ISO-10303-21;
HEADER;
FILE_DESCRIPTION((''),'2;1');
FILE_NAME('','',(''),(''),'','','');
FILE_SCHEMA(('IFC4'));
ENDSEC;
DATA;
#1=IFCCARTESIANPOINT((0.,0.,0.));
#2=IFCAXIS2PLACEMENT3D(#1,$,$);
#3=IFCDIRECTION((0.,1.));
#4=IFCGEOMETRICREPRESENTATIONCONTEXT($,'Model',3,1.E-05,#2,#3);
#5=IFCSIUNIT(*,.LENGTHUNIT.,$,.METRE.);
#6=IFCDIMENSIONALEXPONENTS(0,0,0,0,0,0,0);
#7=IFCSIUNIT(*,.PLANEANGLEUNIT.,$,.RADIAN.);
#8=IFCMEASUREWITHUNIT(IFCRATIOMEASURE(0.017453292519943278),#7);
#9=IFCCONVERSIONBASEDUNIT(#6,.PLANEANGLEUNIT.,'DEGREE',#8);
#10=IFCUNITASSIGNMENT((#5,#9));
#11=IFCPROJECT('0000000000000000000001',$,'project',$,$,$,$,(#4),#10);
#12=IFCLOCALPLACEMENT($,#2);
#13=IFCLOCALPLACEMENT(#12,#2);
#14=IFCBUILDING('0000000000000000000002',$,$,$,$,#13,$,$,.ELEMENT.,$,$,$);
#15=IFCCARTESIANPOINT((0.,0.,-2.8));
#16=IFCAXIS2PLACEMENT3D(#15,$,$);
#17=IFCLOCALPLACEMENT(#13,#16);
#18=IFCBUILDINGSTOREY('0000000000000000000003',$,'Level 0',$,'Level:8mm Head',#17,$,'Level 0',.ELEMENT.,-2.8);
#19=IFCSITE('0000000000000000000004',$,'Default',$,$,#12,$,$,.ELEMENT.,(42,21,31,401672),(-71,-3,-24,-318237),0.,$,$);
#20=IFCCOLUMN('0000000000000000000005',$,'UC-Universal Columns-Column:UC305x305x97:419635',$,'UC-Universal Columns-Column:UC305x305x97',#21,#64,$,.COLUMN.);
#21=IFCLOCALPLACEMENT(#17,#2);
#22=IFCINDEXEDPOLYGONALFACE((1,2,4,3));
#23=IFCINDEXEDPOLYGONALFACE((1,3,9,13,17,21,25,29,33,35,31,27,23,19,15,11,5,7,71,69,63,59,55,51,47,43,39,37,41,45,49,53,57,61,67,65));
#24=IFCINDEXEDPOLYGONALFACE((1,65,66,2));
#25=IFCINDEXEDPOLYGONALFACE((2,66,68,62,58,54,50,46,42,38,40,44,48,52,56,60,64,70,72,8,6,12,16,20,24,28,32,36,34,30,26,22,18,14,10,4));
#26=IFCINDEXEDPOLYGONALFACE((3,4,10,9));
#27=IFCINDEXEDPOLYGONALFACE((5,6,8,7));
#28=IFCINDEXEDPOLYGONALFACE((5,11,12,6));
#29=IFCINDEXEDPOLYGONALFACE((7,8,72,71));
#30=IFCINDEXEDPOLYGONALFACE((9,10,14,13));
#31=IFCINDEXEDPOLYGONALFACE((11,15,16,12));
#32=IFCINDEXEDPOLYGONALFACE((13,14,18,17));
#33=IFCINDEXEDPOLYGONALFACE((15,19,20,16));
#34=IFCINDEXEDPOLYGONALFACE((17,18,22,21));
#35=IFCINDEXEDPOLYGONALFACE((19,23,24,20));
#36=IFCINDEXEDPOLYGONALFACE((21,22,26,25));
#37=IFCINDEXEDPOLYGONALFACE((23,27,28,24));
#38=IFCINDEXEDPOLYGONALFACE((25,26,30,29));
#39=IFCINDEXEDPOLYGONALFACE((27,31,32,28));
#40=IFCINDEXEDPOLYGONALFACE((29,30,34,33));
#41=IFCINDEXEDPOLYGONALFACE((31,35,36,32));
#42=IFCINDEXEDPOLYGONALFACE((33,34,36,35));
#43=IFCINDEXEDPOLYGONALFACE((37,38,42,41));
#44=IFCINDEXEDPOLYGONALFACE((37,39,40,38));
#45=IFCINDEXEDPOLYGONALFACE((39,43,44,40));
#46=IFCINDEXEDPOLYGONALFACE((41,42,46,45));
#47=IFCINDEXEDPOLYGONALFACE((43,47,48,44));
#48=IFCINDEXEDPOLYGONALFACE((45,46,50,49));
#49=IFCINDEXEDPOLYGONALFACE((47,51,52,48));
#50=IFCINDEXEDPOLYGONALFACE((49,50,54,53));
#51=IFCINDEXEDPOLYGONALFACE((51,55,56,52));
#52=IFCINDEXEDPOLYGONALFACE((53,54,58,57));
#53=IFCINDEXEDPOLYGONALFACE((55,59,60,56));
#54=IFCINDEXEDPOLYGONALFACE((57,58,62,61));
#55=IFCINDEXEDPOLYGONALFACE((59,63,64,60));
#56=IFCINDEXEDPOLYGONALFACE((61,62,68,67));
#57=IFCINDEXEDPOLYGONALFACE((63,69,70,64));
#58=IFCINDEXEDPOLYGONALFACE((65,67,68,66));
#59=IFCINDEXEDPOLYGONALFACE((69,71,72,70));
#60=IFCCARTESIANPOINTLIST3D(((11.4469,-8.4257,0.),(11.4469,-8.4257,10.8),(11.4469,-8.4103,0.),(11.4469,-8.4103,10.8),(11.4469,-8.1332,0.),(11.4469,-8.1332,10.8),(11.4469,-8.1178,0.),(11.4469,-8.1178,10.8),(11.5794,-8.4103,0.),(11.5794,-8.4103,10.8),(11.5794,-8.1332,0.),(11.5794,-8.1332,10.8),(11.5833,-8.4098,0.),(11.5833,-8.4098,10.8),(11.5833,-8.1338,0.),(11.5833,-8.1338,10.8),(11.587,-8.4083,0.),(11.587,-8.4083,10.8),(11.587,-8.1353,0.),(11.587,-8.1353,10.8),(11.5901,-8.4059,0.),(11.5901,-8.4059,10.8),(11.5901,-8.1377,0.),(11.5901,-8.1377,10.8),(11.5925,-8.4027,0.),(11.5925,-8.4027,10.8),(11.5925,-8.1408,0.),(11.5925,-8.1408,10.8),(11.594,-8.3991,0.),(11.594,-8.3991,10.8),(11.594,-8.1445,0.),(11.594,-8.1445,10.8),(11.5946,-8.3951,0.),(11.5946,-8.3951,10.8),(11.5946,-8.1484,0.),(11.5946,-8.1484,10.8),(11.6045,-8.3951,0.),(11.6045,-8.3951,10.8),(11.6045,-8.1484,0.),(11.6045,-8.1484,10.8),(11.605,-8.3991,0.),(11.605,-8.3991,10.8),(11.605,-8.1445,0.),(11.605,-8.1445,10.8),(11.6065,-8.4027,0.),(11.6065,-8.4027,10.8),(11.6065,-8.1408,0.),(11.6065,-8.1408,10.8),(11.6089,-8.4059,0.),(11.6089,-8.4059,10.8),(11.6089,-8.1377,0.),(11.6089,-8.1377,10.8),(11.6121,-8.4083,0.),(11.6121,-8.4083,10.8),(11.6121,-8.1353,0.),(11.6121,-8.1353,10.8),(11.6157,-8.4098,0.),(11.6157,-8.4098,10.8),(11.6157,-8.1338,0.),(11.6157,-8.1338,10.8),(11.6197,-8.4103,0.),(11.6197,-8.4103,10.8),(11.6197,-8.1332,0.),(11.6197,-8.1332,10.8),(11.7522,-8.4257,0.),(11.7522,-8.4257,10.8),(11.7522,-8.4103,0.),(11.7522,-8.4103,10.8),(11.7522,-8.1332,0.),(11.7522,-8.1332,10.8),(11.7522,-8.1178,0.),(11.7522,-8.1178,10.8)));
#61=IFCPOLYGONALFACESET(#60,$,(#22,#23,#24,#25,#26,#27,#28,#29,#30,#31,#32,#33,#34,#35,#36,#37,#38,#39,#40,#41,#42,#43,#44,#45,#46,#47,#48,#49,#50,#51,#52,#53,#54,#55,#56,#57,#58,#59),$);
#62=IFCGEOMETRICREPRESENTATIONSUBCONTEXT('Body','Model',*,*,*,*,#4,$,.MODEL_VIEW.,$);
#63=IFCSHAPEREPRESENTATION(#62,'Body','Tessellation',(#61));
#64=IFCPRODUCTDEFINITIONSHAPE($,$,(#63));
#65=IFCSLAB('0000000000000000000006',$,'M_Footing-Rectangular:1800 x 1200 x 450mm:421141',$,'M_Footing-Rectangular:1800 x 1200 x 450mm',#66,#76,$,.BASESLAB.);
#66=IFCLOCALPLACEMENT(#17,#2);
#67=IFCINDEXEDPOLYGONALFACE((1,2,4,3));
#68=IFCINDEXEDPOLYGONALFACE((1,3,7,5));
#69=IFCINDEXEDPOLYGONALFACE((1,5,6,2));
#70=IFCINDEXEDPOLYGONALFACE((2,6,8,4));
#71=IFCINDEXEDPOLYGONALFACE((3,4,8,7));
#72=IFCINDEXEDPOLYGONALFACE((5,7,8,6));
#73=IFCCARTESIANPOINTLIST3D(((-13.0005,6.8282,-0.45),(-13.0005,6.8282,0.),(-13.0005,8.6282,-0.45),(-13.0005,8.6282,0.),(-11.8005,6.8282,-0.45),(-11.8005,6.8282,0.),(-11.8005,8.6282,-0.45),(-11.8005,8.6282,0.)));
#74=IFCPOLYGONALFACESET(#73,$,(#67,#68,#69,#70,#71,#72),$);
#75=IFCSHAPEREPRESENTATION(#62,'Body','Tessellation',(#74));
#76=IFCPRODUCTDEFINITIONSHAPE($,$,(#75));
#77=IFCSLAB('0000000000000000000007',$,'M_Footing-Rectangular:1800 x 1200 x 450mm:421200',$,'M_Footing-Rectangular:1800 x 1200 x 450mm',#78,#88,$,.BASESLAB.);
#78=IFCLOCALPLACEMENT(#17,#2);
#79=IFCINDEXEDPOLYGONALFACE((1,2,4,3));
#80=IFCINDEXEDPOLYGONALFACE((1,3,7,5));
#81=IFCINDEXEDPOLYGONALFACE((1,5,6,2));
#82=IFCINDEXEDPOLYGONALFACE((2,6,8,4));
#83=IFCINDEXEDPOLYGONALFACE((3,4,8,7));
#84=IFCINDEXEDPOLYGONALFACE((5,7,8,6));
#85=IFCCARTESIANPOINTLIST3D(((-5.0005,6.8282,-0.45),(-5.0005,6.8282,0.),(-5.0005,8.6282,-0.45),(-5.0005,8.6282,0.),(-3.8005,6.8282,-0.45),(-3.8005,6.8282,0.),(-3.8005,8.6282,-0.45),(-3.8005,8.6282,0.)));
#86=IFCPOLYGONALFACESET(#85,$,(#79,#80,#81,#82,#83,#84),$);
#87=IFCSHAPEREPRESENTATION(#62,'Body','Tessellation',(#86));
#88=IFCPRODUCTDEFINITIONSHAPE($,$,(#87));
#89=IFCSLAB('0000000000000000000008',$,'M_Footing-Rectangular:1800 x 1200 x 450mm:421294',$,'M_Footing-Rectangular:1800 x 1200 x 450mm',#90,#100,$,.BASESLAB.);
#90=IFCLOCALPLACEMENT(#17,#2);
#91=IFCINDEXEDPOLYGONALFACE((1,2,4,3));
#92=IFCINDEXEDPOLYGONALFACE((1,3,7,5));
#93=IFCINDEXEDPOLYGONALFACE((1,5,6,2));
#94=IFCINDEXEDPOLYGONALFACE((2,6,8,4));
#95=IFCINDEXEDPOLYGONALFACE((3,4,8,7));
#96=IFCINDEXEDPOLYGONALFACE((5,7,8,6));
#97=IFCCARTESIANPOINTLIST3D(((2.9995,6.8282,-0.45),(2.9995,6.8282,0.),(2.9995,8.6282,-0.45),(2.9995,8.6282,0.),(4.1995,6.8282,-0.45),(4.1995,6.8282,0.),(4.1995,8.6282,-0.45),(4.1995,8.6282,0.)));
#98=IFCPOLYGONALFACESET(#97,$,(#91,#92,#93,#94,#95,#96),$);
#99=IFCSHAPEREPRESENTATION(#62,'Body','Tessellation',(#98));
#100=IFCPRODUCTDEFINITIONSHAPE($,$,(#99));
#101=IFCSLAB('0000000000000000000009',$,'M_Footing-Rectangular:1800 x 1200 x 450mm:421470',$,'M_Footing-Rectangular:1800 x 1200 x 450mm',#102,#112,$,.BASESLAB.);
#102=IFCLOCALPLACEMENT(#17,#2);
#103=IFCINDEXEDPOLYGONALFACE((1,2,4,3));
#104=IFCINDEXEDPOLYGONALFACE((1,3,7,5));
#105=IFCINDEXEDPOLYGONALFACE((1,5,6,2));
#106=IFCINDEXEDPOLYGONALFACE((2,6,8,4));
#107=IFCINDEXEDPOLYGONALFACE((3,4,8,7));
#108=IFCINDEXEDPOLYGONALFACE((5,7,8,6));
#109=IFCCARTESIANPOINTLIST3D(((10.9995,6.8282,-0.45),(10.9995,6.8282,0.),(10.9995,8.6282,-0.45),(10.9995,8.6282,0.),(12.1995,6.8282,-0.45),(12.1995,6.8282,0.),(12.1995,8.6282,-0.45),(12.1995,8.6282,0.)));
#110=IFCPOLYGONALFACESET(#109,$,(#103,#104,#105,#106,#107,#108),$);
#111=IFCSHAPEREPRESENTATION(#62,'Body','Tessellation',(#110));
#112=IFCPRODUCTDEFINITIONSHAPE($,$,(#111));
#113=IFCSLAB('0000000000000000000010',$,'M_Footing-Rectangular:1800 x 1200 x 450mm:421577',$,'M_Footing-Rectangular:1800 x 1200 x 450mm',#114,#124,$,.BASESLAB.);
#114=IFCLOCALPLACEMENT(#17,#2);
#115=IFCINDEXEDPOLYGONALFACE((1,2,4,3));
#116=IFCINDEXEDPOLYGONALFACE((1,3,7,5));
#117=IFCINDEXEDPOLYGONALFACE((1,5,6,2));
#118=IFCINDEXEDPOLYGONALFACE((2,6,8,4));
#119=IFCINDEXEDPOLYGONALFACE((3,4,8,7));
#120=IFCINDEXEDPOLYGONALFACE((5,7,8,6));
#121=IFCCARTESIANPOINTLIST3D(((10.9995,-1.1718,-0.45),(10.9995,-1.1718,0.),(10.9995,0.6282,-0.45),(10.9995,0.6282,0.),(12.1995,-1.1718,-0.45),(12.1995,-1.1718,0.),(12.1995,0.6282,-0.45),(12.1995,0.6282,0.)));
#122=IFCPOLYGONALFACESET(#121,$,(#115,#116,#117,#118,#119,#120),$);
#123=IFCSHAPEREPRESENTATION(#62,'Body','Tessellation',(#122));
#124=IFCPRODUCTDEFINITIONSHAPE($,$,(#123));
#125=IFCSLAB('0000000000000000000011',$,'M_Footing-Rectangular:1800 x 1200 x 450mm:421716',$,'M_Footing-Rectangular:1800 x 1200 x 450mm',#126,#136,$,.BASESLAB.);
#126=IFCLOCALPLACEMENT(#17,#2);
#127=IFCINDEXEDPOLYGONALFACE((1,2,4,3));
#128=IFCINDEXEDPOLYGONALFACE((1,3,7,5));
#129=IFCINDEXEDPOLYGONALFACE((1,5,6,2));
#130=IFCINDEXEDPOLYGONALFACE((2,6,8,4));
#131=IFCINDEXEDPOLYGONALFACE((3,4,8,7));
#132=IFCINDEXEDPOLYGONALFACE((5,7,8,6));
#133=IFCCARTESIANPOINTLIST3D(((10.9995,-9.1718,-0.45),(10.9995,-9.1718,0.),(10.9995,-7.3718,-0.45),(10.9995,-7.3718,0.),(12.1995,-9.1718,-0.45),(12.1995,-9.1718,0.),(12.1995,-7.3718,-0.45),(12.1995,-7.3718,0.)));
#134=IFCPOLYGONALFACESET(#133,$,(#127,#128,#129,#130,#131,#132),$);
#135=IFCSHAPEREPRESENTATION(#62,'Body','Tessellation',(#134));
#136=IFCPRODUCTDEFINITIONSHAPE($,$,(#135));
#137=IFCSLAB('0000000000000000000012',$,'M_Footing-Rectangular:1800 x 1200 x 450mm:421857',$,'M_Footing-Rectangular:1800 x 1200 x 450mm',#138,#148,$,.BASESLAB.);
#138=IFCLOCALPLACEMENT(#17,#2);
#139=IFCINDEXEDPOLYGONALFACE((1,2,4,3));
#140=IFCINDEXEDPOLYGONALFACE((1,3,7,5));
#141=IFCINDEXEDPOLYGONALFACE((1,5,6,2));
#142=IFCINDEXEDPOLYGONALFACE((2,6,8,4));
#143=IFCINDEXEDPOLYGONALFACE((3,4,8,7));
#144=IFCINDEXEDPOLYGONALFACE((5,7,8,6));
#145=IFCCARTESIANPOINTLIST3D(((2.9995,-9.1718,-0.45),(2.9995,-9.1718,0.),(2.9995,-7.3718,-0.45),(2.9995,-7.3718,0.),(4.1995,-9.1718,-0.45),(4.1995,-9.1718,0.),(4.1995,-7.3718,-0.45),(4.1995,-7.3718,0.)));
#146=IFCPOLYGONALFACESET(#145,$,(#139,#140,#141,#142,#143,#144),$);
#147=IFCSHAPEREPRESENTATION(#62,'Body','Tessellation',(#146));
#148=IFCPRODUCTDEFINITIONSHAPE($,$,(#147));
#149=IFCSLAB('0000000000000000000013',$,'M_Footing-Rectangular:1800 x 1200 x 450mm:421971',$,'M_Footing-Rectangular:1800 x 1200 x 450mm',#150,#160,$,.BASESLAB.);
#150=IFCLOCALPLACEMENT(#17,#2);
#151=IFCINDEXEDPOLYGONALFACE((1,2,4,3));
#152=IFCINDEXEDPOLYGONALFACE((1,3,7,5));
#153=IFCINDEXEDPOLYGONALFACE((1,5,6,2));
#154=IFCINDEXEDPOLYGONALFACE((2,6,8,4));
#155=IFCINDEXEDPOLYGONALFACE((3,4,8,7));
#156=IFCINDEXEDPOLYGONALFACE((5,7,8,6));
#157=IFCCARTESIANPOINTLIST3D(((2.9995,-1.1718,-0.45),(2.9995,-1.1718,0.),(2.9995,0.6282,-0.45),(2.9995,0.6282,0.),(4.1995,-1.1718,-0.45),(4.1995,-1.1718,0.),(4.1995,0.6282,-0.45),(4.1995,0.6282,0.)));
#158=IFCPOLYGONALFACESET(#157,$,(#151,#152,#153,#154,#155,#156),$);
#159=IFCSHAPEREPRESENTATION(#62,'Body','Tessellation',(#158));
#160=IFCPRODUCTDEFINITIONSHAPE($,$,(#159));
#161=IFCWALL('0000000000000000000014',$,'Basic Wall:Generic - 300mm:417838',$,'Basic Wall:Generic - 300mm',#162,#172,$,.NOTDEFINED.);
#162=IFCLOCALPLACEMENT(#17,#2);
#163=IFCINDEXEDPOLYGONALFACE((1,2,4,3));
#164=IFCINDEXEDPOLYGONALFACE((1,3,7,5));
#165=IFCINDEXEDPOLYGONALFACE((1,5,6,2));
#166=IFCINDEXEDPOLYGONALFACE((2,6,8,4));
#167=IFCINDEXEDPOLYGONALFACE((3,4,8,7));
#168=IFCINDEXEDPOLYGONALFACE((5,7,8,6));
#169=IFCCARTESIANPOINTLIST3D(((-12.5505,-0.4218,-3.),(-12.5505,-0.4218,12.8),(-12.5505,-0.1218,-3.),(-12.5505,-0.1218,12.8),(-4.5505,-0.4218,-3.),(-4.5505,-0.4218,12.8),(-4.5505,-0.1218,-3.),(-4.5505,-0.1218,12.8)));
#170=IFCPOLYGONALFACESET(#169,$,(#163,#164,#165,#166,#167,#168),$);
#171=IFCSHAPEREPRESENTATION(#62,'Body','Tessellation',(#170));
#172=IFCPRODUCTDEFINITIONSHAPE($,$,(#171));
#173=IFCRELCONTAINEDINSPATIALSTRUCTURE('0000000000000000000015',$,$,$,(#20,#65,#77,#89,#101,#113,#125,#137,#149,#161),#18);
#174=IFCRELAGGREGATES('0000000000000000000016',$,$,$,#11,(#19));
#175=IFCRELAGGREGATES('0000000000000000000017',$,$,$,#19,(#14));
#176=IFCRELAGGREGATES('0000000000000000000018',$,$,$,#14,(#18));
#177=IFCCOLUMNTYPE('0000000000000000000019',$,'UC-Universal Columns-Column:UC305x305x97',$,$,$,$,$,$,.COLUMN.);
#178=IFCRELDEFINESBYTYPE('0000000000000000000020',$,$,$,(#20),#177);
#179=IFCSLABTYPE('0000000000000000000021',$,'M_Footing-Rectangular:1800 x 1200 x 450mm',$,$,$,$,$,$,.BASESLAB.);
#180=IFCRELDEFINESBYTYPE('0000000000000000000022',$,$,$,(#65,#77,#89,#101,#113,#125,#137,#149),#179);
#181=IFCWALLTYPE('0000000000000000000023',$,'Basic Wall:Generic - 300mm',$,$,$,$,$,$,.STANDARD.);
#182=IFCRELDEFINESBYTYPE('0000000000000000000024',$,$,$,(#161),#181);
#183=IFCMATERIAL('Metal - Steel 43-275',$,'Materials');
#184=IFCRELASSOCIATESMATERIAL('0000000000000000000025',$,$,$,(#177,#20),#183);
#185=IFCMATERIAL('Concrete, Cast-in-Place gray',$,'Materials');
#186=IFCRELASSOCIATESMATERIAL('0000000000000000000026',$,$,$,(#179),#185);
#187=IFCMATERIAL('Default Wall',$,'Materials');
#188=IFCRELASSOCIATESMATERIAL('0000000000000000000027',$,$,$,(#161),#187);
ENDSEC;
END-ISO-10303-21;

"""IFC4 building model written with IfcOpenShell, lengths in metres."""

from ifc_helpers import new_model, entity, si_unit, converted_unit, direction, frame, origin, place, context, subcontext, project, spatial, line, arc, indexed_curve, outline, extrude, source, transform, mapped, material, type_object, type_shapes, element, save


model = new_model("IFC4")

# Units and contexts
model_context = context("Model", 3, precision=1e-05, world=origin(), true_north=direction((0.0, 1.0)))
body_context = subcontext(model_context, "Body", "Model", "MODEL_VIEW")
ifc_project = project(units=[si_unit("LENGTHUNIT", "METRE"), converted_unit("PLANEANGLEUNIT", "DEGREE", entity("IfcRatioMeasure", 0.017453292519943278), si_unit("PLANEANGLEUNIT", "RADIAN"), dimensions=[0, 0, 0, 0, 0, 0, 0])], contexts=[model_context])

# Site, building, storey
site_placement = place(None, origin())
site = spatial("IfcSite", under=ifc_project, at=site_placement, Name="Default", CompositionType="ELEMENT", RefLatitude=(42, 21, 31, 401672), RefLongitude=(-71, -3, -24, -318237), RefElevation=0.0)
building_placement = place(site_placement, origin())
building = spatial("IfcBuilding", under=site, at=building_placement, CompositionType="ELEMENT")
storey_placement = place(building_placement, frame((0.0, 0.0, -2.8)))
storey = spatial("IfcBuildingStorey", under=building, at=storey_placement, Name="Level 0", ObjectType="Level:8mm Head", LongName="Level 0", CompositionType="ELEMENT", Elevation=-2.8)

# Column
ifc_material_1 = material(Name="Metal - Steel 43-275", Category="Materials")
column_type = type_object("IfcColumnType", Name="UC-Universal Columns-Column:UC305x305x97", PredefinedType="COLUMN", material=ifc_material_1)
shared_shape = source(origin(), body_context, "Body", "SweptSolid", [
    extrude(outline(indexed_curve([(-0.154, -0.1526), (-0.1385, -0.1526), (-0.1385, -0.0202), (-0.1341, -0.0094), (-0.1234, -0.0049), (0.1233, -0.0049), (0.1341, -0.0094), (0.1385, -0.0201), (0.1385, -0.1526), (0.154, -0.1526), (0.154, 0.1526), (0.1385, 0.1526), (0.1385, 0.0202), (0.1341, 0.0094), (0.1234, 0.005), (-0.1233, 0.005), (-0.1341, 0.0094), (-0.1385, 0.0202), (-0.1385, 0.1526), (-0.154, 0.1526)], segments=[line(1, 2, 3), arc(3, 4, 5), line(5, 6), arc(6, 7, 8), line(8, 9, 10, 11, 12, 13), arc(13, 14, 15), line(15, 16), arc(16, 17, 18), line(18, 19, 20, 1)], self_intersect=False)), frame((0.0, 0.0, -2.8), z_axis=(0.0, 0.0, 1.0), x_axis=(0.0, -1.0, 0.0)), (0.0, 0.0, 1.0), 10.8),
])
type_shapes(column_type, [shared_shape])
for number, where, name in (
    (1, (11.5995, -8.2718, 2.8), "UC-Universal Columns-Column:UC305x305x97:419635"),
):
    element("IfcColumn", number, at=place(storey_placement, frame(where)), inside=storey, type_object=column_type, material=ifc_material_1, Name=name, ObjectType="UC-Universal Columns-Column:UC305x305x97", PredefinedType="COLUMN", context=body_context, shape_type="MappedRepresentation", body=[
        mapped(shared_shape, transform((0.0, 0.0, 0.0), scale=1.0)),
    ])

# Slabs
ifc_material_2 = material(Name="Concrete, Cast-in-Place gray", Category="Materials")
slab_type = type_object("IfcSlabType", Name="M_Footing-Rectangular:1800 x 1200 x 450mm", PredefinedType="BASESLAB", material=ifc_material_2)
slab_1_placement = place(storey_placement, origin())
element("IfcSlab", 2, at=slab_1_placement, inside=storey, type_object=slab_type, Name="M_Footing-Rectangular:1800 x 1200 x 450mm:421141", ObjectType="M_Footing-Rectangular:1800 x 1200 x 450mm", PredefinedType="BASESLAB", context=body_context, shape_type="SweptSolid", body=[
    extrude(outline(indexed_curve([(-0.6, -0.9), (0.6, -0.9), (0.6, 0.9), (-0.6, 0.9), (-0.6, -0.9)], self_intersect=False)), frame((-12.4005, 7.7282, -0.45), z_axis=(0.0, 0.0, 1.0), x_axis=(-1.0, 0.0, 0.0)), (0.0, 0.0, 1.0), 0.45),
])
slab_2_placement = place(storey_placement, origin())
element("IfcSlab", 3, at=slab_2_placement, inside=storey, type_object=slab_type, Name="M_Footing-Rectangular:1800 x 1200 x 450mm:421200", ObjectType="M_Footing-Rectangular:1800 x 1200 x 450mm", PredefinedType="BASESLAB", context=body_context, shape_type="SweptSolid", body=[
    extrude(outline(indexed_curve([(-0.6, -0.9), (0.6, -0.9), (0.6, 0.9), (-0.6, 0.9), (-0.6, -0.9)], self_intersect=False)), frame((-4.4005, 7.7282, -0.45), z_axis=(0.0, 0.0, 1.0), x_axis=(-1.0, 0.0, 0.0)), (0.0, 0.0, 1.0), 0.45),
])
slab_3_placement = place(storey_placement, origin())
element("IfcSlab", 4, at=slab_3_placement, inside=storey, type_object=slab_type, Name="M_Footing-Rectangular:1800 x 1200 x 450mm:421294", ObjectType="M_Footing-Rectangular:1800 x 1200 x 450mm", PredefinedType="BASESLAB", context=body_context, shape_type="SweptSolid", body=[
    extrude(outline(indexed_curve([(-0.6, -0.9), (0.6, -0.9), (0.6, 0.9), (-0.6, 0.9), (-0.6, -0.9)], self_intersect=False)), frame((3.5995, 7.7282, -0.45), z_axis=(0.0, 0.0, 1.0), x_axis=(-1.0, 0.0, 0.0)), (0.0, 0.0, 1.0), 0.45),
])
slab_4_placement = place(storey_placement, origin())
element("IfcSlab", 5, at=slab_4_placement, inside=storey, type_object=slab_type, Name="M_Footing-Rectangular:1800 x 1200 x 450mm:421470", ObjectType="M_Footing-Rectangular:1800 x 1200 x 450mm", PredefinedType="BASESLAB", context=body_context, shape_type="SweptSolid", body=[
    extrude(outline(indexed_curve([(-0.6, -0.9), (0.6, -0.9), (0.6, 0.9), (-0.6, 0.9), (-0.6, -0.9)], self_intersect=False)), frame((11.5995, 7.7282, -0.45), z_axis=(0.0, 0.0, 1.0), x_axis=(-1.0, 0.0, 0.0)), (0.0, 0.0, 1.0), 0.45),
])
slab_5_placement = place(storey_placement, origin())
element("IfcSlab", 6, at=slab_5_placement, inside=storey, type_object=slab_type, Name="M_Footing-Rectangular:1800 x 1200 x 450mm:421577", ObjectType="M_Footing-Rectangular:1800 x 1200 x 450mm", PredefinedType="BASESLAB", context=body_context, shape_type="SweptSolid", body=[
    extrude(outline(indexed_curve([(-0.6, -0.9), (0.6, -0.9), (0.6, 0.9), (-0.6, 0.9), (-0.6, -0.9)], self_intersect=False)), frame((11.5995, -0.2718, -0.45), z_axis=(0.0, 0.0, 1.0), x_axis=(-1.0, 0.0, 0.0)), (0.0, 0.0, 1.0), 0.45),
])
slab_6_placement = place(storey_placement, origin())
element("IfcSlab", 7, at=slab_6_placement, inside=storey, type_object=slab_type, Name="M_Footing-Rectangular:1800 x 1200 x 450mm:421716", ObjectType="M_Footing-Rectangular:1800 x 1200 x 450mm", PredefinedType="BASESLAB", context=body_context, shape_type="SweptSolid", body=[
    extrude(outline(indexed_curve([(-0.6, -0.9), (0.6, -0.9), (0.6, 0.9), (-0.6, 0.9), (-0.6, -0.9)], self_intersect=False)), frame((11.5995, -8.2718, -0.45), z_axis=(0.0, 0.0, 1.0), x_axis=(-1.0, 0.0, 0.0)), (0.0, 0.0, 1.0), 0.45),
])
slab_7_placement = place(storey_placement, origin())
element("IfcSlab", 8, at=slab_7_placement, inside=storey, type_object=slab_type, Name="M_Footing-Rectangular:1800 x 1200 x 450mm:421857", ObjectType="M_Footing-Rectangular:1800 x 1200 x 450mm", PredefinedType="BASESLAB", context=body_context, shape_type="SweptSolid", body=[
    extrude(outline(indexed_curve([(-0.6, -0.9), (0.6, -0.9), (0.6, 0.9), (-0.6, 0.9), (-0.6, -0.9)], self_intersect=False)), frame((3.5995, -8.2718, -0.45), z_axis=(0.0, 0.0, 1.0), x_axis=(-1.0, 0.0, 0.0)), (0.0, 0.0, 1.0), 0.45),
])
slab_8_placement = place(storey_placement, origin())
element("IfcSlab", 9, at=slab_8_placement, inside=storey, type_object=slab_type, Name="M_Footing-Rectangular:1800 x 1200 x 450mm:421971", ObjectType="M_Footing-Rectangular:1800 x 1200 x 450mm", PredefinedType="BASESLAB", context=body_context, shape_type="SweptSolid", body=[
    extrude(outline(indexed_curve([(-0.6, -0.9), (0.6, -0.9), (0.6, 0.9), (-0.6, 0.9), (-0.6, -0.9)], self_intersect=False)), frame((3.5995, -0.2718, -0.45), z_axis=(0.0, 0.0, 1.0), x_axis=(-1.0, 0.0, 0.0)), (0.0, 0.0, 1.0), 0.45),
])

# Wall
ifc_material_3 = material(Name="Default Wall", Category="Materials")
wall_type = type_object("IfcWallType", Name="Basic Wall:Generic - 300mm", PredefinedType="STANDARD")
wall_1_placement = place(storey_placement, frame((-12.5505, -0.2718, -3.0)))
element("IfcWall", 10, at=wall_1_placement, inside=storey, type_object=wall_type, material=ifc_material_3, Name="Basic Wall:Generic - 300mm:417838", ObjectType="Basic Wall:Generic - 300mm", PredefinedType="NOTDEFINED", context=body_context, shape_type="SweptSolid", body=[
    extrude(outline(indexed_curve([(8.0, 0.15), (0.0, 0.15), (0.0, -0.15), (8.0, -0.15), (8.0, 0.15)], self_intersect=False)), origin(), (0.0, 0.0, 1.0), 15.8),
])

save(model, "model.ifc")
